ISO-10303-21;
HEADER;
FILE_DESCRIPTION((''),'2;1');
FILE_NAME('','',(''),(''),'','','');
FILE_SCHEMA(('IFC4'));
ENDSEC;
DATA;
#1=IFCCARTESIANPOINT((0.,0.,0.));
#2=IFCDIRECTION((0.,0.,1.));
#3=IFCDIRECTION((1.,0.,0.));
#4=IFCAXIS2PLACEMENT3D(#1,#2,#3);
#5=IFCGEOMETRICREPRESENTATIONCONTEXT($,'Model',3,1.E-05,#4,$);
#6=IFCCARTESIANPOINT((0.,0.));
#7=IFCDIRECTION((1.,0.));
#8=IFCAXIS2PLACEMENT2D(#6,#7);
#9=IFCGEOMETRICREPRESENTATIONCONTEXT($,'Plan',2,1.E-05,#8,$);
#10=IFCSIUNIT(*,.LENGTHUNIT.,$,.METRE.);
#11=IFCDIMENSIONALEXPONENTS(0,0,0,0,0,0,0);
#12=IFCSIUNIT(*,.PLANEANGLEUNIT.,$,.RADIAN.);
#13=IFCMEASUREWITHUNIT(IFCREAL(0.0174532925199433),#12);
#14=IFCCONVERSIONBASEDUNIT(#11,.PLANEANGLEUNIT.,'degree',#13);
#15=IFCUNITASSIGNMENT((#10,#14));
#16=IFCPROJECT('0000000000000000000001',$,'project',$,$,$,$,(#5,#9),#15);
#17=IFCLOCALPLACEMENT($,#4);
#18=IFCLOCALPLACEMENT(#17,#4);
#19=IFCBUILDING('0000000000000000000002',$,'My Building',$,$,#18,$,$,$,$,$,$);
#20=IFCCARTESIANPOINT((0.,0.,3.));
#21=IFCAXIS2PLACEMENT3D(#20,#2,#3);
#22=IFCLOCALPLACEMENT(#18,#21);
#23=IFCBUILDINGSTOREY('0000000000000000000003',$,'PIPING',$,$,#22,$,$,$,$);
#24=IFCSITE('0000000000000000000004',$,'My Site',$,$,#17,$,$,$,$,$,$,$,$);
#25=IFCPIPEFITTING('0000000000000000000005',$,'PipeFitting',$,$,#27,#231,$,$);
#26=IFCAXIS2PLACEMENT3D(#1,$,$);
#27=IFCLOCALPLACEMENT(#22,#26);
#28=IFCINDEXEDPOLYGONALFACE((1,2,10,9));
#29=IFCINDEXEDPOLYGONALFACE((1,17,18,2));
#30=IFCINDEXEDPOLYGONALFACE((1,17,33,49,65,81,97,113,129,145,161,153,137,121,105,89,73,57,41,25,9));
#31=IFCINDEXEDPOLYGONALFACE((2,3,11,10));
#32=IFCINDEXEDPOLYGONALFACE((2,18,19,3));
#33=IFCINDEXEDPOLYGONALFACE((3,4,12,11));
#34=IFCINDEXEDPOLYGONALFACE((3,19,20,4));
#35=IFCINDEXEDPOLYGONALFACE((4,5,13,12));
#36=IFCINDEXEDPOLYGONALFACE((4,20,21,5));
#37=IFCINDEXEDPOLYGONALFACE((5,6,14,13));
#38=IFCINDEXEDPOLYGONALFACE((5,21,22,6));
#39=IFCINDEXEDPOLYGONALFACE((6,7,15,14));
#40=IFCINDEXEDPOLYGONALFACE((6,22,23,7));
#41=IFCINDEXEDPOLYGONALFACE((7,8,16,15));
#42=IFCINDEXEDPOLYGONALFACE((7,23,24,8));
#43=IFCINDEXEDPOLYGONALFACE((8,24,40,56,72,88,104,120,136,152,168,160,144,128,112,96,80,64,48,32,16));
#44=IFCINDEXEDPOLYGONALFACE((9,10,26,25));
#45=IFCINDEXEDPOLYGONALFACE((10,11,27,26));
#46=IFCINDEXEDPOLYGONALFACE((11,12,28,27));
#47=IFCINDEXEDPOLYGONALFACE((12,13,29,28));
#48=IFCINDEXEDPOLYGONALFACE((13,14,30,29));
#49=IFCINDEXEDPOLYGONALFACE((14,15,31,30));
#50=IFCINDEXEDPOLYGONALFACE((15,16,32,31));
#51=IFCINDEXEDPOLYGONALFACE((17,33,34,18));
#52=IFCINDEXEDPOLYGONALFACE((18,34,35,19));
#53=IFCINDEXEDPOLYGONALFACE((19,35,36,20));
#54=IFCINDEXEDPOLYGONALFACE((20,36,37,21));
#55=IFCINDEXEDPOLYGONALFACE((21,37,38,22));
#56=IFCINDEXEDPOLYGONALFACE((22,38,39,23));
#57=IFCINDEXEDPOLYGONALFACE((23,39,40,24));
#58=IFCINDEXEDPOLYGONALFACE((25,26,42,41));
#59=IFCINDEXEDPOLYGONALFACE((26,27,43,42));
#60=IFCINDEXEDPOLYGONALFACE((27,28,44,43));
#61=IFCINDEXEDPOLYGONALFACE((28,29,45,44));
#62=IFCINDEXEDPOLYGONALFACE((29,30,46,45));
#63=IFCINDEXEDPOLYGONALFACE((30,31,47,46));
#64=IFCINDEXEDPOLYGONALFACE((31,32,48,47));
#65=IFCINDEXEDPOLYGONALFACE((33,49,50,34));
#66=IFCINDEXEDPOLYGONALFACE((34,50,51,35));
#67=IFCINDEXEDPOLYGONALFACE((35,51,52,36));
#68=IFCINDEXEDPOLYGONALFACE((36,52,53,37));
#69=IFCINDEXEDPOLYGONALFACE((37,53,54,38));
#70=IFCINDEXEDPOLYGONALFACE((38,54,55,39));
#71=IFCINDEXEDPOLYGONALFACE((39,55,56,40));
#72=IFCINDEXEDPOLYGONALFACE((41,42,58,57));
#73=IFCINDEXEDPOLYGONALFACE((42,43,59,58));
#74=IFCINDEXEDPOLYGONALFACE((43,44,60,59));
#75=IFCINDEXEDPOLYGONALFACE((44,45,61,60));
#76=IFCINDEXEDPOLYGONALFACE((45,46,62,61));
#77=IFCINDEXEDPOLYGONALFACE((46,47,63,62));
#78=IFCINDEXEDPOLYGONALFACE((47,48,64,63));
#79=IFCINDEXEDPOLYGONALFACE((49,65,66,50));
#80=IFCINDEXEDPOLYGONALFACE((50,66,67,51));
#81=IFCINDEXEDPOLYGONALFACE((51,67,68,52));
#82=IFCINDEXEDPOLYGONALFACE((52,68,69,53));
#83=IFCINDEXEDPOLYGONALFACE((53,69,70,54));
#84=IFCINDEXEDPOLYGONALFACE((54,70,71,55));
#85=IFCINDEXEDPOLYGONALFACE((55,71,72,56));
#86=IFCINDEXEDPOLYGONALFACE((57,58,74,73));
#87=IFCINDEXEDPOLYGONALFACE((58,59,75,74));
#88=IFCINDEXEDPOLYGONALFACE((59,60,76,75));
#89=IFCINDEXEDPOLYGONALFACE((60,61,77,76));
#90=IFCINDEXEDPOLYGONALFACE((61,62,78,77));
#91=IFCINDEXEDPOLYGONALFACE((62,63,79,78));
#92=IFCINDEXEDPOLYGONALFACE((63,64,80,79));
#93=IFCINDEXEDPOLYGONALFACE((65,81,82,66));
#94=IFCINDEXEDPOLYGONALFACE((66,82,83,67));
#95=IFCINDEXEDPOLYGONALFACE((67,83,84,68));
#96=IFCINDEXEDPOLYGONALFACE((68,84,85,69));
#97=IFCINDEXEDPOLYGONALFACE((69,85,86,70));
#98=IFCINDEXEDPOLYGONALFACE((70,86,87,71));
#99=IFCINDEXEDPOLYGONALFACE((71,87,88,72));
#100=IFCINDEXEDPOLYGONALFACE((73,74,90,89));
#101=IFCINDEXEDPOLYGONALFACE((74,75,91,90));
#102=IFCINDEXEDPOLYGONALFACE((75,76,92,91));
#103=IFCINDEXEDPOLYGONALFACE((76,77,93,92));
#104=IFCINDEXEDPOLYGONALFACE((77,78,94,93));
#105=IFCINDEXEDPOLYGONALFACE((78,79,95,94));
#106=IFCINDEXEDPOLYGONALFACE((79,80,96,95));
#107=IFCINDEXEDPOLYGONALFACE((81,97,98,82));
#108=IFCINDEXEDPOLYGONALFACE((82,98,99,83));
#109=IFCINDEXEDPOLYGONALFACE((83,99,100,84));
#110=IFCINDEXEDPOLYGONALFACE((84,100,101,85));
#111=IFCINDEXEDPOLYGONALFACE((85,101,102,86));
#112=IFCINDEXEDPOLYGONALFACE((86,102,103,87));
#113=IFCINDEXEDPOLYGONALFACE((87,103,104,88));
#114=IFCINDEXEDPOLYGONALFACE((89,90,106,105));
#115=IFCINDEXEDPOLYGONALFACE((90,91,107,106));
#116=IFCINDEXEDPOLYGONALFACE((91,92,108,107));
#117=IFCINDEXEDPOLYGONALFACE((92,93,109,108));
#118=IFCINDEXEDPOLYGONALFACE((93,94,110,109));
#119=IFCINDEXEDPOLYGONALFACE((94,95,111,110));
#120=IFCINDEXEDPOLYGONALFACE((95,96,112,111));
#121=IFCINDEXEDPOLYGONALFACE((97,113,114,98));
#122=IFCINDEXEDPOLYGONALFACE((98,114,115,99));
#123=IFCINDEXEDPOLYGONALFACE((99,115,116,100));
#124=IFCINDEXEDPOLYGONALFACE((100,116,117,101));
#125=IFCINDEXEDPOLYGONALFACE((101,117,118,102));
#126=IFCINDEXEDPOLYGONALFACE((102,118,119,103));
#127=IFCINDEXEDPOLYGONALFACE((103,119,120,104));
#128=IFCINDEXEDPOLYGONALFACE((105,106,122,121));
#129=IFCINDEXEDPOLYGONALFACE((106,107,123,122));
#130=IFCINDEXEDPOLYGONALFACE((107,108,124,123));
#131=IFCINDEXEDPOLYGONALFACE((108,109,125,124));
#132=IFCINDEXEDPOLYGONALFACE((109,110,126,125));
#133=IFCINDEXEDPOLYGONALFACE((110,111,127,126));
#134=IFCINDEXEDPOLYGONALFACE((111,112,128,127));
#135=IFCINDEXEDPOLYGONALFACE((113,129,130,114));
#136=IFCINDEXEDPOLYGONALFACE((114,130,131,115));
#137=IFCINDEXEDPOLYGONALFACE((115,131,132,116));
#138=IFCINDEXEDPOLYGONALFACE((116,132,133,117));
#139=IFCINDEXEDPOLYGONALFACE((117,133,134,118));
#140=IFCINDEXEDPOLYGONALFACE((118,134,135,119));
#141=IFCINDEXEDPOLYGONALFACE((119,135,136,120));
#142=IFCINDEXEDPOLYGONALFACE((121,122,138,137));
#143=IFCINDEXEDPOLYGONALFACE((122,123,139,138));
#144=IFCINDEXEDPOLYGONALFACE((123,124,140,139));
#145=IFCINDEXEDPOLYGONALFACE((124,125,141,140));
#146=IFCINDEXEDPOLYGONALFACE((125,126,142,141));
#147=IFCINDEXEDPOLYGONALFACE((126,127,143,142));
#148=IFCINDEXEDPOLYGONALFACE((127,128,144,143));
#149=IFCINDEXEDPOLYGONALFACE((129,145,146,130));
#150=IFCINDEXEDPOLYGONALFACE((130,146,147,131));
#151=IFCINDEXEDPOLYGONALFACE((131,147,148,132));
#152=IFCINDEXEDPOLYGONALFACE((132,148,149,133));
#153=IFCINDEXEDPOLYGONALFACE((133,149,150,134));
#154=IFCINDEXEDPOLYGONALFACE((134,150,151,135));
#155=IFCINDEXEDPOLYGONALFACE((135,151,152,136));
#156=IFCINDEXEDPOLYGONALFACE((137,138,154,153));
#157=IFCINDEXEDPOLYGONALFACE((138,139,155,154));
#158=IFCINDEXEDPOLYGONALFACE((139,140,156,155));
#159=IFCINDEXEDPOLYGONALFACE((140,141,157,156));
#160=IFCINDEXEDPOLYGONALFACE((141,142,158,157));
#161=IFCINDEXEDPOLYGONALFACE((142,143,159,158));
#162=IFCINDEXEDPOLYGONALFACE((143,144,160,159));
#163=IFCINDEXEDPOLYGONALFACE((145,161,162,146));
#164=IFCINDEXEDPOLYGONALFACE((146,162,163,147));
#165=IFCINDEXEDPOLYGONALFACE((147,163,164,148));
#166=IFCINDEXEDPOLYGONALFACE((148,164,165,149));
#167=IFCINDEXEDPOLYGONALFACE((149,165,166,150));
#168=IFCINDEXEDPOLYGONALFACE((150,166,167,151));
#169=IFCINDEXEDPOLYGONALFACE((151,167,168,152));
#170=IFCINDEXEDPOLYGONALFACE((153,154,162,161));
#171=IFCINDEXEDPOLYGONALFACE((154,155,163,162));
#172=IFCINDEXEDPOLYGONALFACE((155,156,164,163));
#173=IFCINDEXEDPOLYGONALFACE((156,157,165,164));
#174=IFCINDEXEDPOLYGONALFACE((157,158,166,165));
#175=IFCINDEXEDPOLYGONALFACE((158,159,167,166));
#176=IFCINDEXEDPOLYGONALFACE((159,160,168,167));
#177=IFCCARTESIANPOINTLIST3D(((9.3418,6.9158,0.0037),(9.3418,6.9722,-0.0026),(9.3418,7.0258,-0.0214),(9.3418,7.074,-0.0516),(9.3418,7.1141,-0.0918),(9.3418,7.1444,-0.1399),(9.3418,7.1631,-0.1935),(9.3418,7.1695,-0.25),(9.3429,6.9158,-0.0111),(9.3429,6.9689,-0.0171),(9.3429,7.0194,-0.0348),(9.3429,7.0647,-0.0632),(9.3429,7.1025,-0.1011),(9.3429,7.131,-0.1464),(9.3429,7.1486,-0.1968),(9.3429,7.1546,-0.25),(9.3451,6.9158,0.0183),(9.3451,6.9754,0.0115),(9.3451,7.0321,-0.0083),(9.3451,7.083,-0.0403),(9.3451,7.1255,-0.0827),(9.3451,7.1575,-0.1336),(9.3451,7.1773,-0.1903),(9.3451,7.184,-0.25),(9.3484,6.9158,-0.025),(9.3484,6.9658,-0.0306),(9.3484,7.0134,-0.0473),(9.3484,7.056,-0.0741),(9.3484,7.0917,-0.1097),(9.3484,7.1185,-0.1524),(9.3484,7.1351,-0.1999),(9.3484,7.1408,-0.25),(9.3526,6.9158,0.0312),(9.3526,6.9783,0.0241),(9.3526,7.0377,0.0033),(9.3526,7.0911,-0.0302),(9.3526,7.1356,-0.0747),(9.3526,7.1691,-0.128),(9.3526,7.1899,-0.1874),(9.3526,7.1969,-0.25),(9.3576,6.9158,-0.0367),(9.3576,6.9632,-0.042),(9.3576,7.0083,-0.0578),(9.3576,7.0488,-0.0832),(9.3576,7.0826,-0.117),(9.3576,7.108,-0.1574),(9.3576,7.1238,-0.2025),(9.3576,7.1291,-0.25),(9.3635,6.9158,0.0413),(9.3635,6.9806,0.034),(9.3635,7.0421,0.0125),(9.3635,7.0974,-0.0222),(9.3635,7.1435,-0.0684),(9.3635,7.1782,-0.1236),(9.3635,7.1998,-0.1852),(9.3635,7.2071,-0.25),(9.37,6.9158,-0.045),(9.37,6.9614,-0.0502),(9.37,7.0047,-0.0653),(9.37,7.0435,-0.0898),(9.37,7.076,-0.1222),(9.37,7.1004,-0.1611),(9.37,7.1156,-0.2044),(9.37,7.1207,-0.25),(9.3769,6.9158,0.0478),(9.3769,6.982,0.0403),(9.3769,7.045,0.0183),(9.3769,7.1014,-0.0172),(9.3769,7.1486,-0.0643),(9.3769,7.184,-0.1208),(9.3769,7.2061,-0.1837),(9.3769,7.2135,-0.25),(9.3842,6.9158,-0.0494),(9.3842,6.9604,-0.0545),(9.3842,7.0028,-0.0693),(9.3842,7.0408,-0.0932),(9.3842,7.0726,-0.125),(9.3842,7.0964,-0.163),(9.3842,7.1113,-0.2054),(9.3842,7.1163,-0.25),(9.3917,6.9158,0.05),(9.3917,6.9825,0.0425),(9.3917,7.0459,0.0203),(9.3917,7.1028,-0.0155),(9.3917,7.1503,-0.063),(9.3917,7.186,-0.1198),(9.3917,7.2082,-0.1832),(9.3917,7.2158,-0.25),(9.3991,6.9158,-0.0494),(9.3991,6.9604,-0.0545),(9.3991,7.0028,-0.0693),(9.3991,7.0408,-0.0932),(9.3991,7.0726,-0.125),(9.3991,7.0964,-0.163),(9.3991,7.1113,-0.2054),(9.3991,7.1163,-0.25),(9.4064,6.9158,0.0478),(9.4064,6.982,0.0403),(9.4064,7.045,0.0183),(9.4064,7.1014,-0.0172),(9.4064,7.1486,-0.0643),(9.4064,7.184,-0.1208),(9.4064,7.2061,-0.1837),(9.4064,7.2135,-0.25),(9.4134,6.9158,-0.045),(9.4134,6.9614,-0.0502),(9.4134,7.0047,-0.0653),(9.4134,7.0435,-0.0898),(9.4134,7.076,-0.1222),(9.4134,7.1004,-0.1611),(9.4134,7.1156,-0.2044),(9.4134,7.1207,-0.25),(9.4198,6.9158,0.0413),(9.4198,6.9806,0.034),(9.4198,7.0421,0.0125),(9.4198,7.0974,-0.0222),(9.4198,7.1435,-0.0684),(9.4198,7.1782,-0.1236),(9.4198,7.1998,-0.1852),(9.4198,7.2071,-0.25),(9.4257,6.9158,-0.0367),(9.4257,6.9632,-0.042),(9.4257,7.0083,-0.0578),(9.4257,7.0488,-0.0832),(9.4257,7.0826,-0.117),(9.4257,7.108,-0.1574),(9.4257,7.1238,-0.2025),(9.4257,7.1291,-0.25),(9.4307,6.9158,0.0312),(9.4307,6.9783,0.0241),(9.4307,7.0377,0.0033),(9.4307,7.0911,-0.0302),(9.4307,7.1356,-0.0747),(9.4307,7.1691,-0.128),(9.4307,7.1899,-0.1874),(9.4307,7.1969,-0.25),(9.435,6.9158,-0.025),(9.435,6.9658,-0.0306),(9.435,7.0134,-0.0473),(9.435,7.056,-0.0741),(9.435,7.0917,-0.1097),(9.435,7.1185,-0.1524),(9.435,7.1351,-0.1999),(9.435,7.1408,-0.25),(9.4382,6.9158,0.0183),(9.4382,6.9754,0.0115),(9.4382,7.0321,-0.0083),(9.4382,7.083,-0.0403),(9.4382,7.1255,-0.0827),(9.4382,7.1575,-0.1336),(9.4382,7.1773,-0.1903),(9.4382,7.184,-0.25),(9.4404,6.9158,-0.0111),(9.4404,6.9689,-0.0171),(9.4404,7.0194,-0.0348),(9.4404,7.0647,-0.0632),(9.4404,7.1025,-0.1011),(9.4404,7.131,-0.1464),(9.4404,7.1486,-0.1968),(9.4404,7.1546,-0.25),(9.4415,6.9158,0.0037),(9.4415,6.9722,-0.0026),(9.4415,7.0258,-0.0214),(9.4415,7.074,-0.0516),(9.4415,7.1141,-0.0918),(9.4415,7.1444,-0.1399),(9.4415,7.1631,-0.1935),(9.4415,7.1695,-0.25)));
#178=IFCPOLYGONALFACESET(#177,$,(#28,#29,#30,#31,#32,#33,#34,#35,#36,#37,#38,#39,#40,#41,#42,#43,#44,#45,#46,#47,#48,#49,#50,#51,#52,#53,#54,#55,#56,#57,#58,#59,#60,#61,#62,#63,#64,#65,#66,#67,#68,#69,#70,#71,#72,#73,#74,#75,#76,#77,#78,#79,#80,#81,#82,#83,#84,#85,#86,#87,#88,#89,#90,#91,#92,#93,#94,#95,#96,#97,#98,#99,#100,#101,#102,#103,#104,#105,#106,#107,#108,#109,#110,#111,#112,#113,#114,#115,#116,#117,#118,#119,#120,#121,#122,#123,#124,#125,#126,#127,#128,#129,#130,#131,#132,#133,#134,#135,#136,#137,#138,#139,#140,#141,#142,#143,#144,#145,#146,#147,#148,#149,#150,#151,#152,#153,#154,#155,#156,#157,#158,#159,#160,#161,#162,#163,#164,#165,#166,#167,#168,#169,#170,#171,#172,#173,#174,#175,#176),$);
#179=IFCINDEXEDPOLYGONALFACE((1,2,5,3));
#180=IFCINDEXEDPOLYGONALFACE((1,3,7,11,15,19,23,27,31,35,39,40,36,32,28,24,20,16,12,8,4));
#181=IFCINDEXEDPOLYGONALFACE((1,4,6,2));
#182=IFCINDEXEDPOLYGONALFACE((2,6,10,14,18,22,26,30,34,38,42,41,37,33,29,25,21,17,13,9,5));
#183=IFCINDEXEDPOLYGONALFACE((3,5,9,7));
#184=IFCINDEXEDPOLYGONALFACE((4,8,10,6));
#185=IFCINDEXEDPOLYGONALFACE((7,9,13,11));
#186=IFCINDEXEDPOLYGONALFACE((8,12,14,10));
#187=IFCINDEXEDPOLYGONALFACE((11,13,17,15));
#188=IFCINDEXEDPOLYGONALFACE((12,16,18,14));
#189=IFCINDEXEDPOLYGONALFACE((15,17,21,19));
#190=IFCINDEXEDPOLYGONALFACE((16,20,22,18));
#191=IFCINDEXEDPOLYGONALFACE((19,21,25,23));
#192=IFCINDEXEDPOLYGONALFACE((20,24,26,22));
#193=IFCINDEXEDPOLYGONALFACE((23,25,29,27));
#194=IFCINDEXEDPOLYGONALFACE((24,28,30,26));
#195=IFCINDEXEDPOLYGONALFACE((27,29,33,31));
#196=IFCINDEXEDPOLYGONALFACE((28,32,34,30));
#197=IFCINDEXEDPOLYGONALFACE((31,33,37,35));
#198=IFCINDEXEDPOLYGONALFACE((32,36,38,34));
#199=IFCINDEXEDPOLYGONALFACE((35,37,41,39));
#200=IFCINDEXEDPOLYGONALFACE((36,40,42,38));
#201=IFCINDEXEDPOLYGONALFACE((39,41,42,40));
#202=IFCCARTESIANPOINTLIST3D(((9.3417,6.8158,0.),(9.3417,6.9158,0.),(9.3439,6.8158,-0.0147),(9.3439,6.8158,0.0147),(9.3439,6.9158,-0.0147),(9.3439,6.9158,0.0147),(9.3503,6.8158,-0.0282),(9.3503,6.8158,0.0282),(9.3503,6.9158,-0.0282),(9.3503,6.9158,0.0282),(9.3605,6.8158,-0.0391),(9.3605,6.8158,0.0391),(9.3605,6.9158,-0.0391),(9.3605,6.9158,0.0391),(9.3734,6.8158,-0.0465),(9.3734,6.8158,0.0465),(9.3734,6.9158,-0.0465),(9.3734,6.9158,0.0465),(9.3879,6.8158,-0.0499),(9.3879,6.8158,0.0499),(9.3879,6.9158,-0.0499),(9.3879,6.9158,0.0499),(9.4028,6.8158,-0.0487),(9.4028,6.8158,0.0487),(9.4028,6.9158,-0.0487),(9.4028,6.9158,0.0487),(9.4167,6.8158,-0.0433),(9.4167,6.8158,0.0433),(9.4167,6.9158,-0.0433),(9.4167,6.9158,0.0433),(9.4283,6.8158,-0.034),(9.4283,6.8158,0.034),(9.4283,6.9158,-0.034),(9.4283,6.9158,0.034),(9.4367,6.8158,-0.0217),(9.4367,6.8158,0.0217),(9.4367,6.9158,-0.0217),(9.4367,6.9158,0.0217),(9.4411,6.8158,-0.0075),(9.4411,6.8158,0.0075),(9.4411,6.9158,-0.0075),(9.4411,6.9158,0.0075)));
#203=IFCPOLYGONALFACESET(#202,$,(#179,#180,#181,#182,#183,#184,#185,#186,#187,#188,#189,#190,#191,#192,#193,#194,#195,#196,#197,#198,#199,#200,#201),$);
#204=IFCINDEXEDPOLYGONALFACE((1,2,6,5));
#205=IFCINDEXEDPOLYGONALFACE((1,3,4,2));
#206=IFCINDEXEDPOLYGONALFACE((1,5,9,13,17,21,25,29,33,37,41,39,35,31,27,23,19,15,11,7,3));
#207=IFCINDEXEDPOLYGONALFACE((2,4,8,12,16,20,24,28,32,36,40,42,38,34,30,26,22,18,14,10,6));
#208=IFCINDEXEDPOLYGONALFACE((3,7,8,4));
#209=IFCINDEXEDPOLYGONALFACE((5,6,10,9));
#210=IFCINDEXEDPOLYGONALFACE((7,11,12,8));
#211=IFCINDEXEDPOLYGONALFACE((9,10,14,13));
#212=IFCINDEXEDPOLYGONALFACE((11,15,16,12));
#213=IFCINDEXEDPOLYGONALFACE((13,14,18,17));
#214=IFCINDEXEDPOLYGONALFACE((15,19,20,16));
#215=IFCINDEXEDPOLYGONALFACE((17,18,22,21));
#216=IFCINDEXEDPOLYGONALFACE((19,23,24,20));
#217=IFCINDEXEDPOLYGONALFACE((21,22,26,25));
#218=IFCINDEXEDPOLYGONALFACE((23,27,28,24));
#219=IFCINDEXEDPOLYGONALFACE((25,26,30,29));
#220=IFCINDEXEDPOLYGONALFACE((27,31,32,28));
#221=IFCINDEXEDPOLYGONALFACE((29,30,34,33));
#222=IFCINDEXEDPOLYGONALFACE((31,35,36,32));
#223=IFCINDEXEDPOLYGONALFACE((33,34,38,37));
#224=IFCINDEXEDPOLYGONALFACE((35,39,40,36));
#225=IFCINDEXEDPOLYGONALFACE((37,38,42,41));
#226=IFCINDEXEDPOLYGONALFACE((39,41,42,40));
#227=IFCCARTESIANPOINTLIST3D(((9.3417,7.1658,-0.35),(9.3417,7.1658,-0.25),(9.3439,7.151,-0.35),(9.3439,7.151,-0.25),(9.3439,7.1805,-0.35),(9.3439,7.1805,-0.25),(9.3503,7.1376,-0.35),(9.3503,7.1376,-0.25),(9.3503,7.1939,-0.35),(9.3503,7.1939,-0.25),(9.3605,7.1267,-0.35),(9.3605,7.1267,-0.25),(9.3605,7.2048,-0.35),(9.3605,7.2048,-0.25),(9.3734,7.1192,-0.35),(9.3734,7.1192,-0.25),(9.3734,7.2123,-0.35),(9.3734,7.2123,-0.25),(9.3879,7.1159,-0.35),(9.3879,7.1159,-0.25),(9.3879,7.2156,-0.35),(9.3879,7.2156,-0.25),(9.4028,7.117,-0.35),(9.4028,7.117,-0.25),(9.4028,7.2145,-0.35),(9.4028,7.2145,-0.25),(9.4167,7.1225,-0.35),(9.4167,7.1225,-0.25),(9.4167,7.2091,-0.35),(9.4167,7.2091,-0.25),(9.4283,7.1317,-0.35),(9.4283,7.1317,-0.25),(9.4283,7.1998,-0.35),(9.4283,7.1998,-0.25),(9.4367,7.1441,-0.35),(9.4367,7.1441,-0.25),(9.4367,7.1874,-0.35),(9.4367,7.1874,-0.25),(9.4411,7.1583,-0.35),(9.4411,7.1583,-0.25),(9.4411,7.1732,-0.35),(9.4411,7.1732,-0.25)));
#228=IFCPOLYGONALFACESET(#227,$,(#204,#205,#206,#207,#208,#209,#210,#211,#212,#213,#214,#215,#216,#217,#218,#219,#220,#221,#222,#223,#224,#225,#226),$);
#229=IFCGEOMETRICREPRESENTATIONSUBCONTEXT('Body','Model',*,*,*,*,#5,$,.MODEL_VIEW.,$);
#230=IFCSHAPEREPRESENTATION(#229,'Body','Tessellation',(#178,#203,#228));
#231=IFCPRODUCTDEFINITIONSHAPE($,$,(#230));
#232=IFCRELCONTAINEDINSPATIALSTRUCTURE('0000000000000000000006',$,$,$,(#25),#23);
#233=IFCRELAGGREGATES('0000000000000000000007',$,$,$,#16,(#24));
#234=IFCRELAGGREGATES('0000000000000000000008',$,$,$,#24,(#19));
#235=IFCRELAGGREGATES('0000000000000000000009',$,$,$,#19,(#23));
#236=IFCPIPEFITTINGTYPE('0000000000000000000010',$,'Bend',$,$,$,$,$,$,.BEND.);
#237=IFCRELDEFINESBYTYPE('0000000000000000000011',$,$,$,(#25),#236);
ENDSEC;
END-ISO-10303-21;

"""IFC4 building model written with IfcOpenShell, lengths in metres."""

from ifc_helpers import new_model, entity, si_unit, converted_unit, frame, origin_with_axes, origin_2d_with_axis, place, context, subcontext, project, spatial, line, indexed_curve, circle, outline, extrude, source, transform, mapped, type_object, type_shapes, element, save


model = new_model("IFC4")

# Units and contexts
model_context = context("Model", 3, precision=1e-05, world=origin_with_axes())
plan_context = context("Plan", 2, precision=1e-05, world=origin_2d_with_axis())
body_context = subcontext(model_context, "Body", "Model", "MODEL_VIEW")
ifc_project = project(units=[si_unit("LENGTHUNIT", "METRE"), converted_unit("PLANEANGLEUNIT", "degree", entity("IfcReal", 0.0174532925199433), si_unit("PLANEANGLEUNIT", "RADIAN"), dimensions=[0, 0, 0, 0, 0, 0, 0])], contexts=[model_context, plan_context])

# Site, building, storey
site_placement = place(None, origin_with_axes())
site = spatial("IfcSite", under=ifc_project, at=site_placement, Name="My Site")
building_placement = place(site_placement, origin_with_axes())
building = spatial("IfcBuilding", under=site, at=building_placement, Name="My Building")
storey_placement = place(building_placement, frame((0.0, 0.0, 3.0), z_axis=(0.0, 0.0, 1.0), x_axis=(1.0, 0.0, 0.0)))
storey = spatial("IfcBuildingStorey", under=building, at=storey_placement, Name="PIPING")

# Pipe fitting, opening
pipe_fitting_type = type_object("IfcPipeFittingType", Name="Bend", PredefinedType="BEND")
shared_shape = source(origin_with_axes(), body_context, "Body", "SolidModel", [
    entity("IfcSweptDiskSolid", entity("IfcIndexedPolyCurve", entity("IfcCartesianPointList3D", [[0.0, 0.0, 0.1], [0.0, -0.0732, 0.2768], [0.0, -0.25, 0.35]]), [entity("IfcArcIndex", [1, 2, 3])]), 0.05),
    extrude(circle(Radius=0.05), origin_with_axes(), (0.0, 0.0, 1.0), 0.1),
    extrude(circle(Radius=0.05), frame((0.0, -0.25, 0.35), z_axis=(0.0, -1.0, 0.0), x_axis=(1.0, 0.0, 0.0)), (0.0, 0.0, 1.0), 0.1),
])
type_shapes(pipe_fitting_type, [shared_shape])
pipe_fitting_1_placement = place(storey_placement, frame((9.3917, 6.8158, 0.0), z_axis=(0.0, 1.0, 0.0), x_axis=(-1.0, 0.0, 0.0)))
pipe_fitting_1 = element("IfcPipeFitting", 1, at=pipe_fitting_1_placement, inside=storey, type_object=pipe_fitting_type, Name="PipeFitting", context=body_context, shape_type="MappedRepresentation", body=[
    mapped(shared_shape, transform((0.0, 0.0, 0.0), x_axis=(1.0, 0.0, 0.0), y_axis=(0.0, 1.0, 0.0), z_axis=(0.0, 0.0, 1.0), scale=1.0)),
])
opening_1_placement = place(pipe_fitting_1_placement, frame((9.3917, -3.0, -6.8158), z_axis=(0.0, 1.0, 0.0), x_axis=(-1.0, 0.0, 0.0)))
element("IfcOpeningElement", 2, at=opening_1_placement, cuts=pipe_fitting_1, PredefinedType="OPENING", context=body_context, shape_type="SweptSolid", body=[
    extrude(outline(indexed_curve([(0.0, 0.0), (0.5, 0.0), (0.5, 0.5), (0.0, 0.5)], segments=[line(1, 2, 3, 4, 1)])), origin_with_axes(), (0.0, 0.0, 1.0), 0.5),
])

save(model, "model.ifc")
